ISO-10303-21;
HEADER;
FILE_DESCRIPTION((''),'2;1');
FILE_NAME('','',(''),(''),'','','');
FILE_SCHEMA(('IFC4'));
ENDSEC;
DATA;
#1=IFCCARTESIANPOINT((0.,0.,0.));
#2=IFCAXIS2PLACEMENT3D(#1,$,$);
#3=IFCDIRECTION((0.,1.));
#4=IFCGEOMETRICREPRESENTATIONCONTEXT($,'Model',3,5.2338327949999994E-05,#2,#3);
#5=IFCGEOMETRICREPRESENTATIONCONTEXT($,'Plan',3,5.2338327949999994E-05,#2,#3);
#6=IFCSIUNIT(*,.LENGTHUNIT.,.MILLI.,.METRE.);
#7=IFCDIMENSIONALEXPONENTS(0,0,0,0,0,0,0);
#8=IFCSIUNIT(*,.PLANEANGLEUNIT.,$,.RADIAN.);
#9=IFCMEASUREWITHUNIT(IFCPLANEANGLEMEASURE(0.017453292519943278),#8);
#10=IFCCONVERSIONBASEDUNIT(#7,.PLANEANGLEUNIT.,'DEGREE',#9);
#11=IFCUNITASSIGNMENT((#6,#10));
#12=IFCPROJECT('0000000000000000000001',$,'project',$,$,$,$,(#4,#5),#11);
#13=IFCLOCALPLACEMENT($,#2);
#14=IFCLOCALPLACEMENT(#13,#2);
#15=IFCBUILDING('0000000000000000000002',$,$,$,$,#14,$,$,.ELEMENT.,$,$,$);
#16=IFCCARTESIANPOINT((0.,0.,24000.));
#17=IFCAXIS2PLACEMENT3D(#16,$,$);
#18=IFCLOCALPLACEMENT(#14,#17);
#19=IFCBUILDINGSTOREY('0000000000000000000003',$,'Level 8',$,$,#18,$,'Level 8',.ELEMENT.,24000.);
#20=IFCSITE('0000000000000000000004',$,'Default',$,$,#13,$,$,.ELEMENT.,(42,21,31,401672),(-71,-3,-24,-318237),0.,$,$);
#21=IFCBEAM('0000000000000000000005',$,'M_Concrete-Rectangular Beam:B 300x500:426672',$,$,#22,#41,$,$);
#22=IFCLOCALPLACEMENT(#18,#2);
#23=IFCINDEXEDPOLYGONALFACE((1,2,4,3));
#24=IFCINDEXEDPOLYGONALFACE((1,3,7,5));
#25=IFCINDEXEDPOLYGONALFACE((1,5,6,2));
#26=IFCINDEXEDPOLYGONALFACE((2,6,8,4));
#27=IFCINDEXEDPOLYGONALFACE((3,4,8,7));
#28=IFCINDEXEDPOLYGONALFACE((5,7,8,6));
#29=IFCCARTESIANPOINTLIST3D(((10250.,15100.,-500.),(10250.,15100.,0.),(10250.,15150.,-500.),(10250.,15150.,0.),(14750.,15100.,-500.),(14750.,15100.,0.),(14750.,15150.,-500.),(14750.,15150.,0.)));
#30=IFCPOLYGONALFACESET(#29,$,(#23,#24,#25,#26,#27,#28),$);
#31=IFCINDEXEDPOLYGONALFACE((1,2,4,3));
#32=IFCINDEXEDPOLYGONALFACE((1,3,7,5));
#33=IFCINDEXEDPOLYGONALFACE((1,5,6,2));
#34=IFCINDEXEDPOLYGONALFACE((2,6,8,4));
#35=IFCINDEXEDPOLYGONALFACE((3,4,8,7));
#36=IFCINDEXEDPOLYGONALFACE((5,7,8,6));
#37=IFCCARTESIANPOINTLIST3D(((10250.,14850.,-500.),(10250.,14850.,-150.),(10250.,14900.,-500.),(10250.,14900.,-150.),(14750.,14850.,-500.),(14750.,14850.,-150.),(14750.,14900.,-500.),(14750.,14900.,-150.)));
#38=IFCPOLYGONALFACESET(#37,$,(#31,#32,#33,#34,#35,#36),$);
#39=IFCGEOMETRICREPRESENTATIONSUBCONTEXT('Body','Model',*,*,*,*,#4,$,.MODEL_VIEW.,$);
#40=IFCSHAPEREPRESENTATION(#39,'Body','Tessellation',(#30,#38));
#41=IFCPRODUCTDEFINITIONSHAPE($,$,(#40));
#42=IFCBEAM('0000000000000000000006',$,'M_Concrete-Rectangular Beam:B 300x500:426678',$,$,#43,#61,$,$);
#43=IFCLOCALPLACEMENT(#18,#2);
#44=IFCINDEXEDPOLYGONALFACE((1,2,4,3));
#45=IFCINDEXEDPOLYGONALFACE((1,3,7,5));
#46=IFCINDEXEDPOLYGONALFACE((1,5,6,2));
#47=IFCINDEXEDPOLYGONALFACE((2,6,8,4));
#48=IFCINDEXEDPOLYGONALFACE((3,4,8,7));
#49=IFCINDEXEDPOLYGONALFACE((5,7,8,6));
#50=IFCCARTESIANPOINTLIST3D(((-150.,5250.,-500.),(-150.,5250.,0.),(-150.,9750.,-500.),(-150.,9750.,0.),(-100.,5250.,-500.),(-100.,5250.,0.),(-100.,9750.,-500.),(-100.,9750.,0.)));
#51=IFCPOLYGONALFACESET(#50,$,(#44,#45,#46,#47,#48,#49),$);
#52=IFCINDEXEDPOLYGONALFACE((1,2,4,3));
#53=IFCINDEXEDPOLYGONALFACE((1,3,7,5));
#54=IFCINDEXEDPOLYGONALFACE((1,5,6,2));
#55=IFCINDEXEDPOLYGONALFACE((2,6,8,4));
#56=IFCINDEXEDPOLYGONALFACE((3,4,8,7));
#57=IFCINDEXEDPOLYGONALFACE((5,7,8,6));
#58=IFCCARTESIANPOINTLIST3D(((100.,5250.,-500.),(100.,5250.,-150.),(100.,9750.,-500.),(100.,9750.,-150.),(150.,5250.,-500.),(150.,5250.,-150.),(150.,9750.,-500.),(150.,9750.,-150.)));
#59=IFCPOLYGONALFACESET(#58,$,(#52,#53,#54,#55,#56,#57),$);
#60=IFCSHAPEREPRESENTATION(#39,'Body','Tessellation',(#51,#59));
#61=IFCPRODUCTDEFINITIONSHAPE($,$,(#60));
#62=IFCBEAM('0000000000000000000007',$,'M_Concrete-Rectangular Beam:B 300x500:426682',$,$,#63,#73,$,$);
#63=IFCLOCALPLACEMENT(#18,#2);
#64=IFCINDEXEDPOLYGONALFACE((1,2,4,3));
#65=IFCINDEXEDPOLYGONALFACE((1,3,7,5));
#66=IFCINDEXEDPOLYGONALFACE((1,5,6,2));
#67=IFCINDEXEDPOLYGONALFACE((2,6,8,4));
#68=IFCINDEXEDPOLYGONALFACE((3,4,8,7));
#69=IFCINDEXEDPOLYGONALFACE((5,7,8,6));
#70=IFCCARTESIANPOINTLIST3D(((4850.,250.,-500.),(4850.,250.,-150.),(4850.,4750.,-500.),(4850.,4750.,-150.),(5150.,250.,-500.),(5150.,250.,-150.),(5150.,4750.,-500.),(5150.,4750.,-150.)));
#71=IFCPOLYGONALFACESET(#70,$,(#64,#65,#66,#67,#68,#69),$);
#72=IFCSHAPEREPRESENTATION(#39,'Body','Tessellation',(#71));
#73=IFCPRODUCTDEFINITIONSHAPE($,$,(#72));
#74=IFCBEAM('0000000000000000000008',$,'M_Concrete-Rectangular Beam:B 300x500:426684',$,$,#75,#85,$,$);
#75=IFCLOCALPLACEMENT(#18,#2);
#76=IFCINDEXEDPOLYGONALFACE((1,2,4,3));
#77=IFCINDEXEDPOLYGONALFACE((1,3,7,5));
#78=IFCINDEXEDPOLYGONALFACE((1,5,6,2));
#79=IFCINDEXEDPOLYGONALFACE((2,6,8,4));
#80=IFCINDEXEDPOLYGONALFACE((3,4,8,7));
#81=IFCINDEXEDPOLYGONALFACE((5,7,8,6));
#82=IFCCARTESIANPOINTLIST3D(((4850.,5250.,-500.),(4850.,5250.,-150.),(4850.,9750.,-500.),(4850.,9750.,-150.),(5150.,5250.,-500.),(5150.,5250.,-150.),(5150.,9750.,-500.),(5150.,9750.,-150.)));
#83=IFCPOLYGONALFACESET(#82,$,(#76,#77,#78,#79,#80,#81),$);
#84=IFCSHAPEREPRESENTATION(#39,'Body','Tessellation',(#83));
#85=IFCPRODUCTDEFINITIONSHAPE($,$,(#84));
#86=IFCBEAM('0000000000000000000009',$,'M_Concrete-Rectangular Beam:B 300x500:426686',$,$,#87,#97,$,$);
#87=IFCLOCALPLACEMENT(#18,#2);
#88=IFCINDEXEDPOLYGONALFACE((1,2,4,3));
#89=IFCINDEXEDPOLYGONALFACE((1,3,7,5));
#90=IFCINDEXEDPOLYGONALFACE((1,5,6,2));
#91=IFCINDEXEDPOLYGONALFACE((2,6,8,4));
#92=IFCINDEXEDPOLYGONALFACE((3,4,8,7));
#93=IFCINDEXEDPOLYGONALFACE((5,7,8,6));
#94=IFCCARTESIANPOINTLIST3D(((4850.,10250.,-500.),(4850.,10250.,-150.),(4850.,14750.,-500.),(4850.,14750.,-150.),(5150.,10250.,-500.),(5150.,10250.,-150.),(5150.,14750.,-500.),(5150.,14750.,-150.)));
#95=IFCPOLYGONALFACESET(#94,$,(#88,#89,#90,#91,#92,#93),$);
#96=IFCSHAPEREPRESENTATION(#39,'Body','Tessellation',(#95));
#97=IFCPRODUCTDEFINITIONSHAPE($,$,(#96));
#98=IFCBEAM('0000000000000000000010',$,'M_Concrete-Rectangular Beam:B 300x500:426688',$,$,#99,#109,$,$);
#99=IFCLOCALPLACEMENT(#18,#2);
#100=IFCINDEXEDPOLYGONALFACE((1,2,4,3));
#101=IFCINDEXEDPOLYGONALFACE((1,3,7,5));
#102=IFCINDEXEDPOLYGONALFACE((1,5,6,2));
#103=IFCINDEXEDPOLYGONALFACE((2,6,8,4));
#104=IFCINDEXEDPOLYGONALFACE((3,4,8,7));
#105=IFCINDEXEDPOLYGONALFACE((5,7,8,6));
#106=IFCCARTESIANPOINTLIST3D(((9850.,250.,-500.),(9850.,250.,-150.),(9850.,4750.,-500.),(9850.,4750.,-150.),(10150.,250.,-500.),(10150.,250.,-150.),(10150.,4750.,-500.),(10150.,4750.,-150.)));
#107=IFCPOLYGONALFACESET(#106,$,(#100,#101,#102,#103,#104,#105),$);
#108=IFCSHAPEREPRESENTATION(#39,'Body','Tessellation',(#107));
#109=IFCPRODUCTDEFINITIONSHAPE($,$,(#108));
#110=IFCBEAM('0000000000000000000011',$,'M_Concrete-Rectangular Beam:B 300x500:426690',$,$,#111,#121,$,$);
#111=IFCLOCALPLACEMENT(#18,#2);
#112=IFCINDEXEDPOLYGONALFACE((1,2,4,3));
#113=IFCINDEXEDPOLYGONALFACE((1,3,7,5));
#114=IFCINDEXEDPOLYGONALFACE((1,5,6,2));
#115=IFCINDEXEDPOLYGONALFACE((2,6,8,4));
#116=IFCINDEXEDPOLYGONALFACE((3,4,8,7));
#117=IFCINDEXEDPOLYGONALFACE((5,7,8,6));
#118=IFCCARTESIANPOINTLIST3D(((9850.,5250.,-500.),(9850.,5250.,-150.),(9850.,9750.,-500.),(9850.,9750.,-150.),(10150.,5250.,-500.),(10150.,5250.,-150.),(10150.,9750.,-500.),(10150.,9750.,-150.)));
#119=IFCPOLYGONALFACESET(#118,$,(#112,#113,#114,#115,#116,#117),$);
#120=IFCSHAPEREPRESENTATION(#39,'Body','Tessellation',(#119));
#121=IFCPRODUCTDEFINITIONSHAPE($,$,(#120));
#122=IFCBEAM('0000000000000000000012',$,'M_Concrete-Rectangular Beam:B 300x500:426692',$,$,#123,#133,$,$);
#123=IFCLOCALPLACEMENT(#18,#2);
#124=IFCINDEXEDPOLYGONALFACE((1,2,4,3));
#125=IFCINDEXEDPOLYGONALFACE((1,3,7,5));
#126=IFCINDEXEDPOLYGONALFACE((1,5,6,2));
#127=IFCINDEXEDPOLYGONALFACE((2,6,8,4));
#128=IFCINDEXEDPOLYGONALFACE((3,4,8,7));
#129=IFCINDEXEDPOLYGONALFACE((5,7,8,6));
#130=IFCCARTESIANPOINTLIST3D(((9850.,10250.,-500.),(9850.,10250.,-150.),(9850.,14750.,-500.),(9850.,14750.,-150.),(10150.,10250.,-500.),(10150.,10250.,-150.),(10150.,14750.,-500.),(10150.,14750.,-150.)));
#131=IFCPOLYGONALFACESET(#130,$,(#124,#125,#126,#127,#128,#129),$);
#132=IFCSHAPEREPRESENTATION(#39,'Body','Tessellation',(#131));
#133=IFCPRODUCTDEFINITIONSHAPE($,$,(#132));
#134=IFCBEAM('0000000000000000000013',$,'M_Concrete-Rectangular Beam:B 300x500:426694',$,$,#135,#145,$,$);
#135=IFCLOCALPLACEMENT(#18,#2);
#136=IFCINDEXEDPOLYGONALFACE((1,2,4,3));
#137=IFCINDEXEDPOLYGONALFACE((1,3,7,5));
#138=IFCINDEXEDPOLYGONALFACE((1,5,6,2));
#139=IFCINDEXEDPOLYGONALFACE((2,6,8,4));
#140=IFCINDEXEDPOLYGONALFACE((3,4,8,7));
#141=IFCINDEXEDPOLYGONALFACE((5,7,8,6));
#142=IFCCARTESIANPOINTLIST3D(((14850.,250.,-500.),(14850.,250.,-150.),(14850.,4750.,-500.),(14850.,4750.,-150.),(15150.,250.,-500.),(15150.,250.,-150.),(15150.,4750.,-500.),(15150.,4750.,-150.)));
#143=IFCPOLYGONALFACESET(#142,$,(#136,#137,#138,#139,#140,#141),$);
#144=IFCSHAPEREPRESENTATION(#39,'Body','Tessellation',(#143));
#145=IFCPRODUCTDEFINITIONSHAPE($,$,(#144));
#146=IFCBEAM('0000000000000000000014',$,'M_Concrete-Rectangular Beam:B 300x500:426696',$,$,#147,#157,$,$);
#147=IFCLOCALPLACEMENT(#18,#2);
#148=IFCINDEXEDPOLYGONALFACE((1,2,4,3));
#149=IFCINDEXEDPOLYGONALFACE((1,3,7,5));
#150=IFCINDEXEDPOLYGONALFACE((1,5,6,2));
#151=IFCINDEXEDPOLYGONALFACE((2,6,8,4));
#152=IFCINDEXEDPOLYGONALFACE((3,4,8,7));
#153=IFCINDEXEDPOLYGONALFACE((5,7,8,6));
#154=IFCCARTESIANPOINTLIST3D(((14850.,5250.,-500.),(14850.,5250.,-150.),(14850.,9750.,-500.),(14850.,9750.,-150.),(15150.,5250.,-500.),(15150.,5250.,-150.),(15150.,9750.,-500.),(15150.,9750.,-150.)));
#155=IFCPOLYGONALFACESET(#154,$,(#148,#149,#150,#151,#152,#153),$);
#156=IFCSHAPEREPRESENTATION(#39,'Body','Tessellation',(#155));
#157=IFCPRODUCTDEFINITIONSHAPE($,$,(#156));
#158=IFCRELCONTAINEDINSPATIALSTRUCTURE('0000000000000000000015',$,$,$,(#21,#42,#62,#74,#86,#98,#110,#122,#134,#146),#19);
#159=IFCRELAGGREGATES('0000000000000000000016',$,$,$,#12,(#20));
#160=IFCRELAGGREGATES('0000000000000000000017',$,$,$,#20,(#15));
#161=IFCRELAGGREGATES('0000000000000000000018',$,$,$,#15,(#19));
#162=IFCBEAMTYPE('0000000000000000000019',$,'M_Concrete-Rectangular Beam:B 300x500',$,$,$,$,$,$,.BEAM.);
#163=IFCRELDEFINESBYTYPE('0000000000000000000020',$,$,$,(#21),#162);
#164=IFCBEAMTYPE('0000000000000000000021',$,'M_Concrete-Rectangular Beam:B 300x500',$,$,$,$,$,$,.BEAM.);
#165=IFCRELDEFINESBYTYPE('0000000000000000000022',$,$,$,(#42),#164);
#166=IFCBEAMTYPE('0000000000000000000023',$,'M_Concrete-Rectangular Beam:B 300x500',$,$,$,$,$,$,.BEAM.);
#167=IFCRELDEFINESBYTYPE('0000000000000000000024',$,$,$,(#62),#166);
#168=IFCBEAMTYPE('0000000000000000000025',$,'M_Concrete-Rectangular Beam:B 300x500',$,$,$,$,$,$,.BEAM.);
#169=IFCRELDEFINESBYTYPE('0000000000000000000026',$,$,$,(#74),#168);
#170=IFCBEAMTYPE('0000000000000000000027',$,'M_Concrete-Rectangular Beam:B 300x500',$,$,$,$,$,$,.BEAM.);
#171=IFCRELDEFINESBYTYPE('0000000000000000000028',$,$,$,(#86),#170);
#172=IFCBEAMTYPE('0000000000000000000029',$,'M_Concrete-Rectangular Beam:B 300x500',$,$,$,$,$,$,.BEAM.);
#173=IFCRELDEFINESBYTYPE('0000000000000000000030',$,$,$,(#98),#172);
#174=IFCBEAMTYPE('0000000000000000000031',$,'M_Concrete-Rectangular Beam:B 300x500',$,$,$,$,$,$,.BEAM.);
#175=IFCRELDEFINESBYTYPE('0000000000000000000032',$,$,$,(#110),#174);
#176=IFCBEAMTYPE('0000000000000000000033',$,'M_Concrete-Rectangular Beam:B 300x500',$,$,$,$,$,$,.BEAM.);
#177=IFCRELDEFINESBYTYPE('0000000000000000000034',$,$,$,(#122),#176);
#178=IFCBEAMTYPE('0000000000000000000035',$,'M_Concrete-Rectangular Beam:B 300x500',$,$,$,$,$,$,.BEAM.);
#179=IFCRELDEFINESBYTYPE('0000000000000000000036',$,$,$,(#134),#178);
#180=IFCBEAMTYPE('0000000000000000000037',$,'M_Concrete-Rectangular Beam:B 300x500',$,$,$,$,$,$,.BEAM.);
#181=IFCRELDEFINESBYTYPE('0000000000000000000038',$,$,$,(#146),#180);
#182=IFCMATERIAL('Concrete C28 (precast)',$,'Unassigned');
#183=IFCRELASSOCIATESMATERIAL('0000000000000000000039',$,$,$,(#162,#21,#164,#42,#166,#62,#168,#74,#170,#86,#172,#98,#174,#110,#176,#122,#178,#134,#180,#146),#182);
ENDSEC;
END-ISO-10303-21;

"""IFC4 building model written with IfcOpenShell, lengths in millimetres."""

from ifc_helpers import new_model, entity, si_unit, converted_unit, direction, frame, origin, place, context, subcontext, project, spatial, indexed_curve, outline, extrude, source, transform, mapped, material, type_object, type_shapes, element, save


model = new_model("IFC4")

# Units and contexts
model_context = context("Model", 3, precision=5.2338327949999994e-05, world=origin(), true_north=direction((0.0, 1.0)))
plan_context = context("Plan", 3, precision=5.2338327949999994e-05, world=origin(), true_north=direction((0.0, 1.0)))
body_context = subcontext(model_context, "Body", "Model", "MODEL_VIEW")
ifc_project = project(units=[si_unit("LENGTHUNIT", "METRE", prefix="MILLI"), converted_unit("PLANEANGLEUNIT", "DEGREE", entity("IfcPlaneAngleMeasure", 0.017453292519943278), si_unit("PLANEANGLEUNIT", "RADIAN"), dimensions=[0, 0, 0, 0, 0, 0, 0])], contexts=[model_context, plan_context])

# Site, building, storey
site_placement = place(None, origin())
site = spatial("IfcSite", under=ifc_project, at=site_placement, Name="Default", CompositionType="ELEMENT", RefLatitude=(42, 21, 31, 401672), RefLongitude=(-71, -3, -24, -318237), RefElevation=0.0)
building_placement = place(site_placement, origin())
building = spatial("IfcBuilding", under=site, at=building_placement, CompositionType="ELEMENT")
storey_placement = place(building_placement, frame((0.0, 0.0, 24000.0)))
storey = spatial("IfcBuildingStorey", under=building, at=storey_placement, Name="Level 8", LongName="Level 8", CompositionType="ELEMENT", Elevation=24000.0)

# Beams
ifc_material = material(Name="Concrete C28 (precast)", Category="Unassigned")
beam_type_1 = type_object("IfcBeamType", Name="M_Concrete-Rectangular Beam:B 300x500", PredefinedType="BEAM", material=ifc_material)
shared_shape_1 = source(origin(), body_context, "Body", "SweptSolid", [
    extrude(outline(indexed_curve([(-250.0, -25.0), (250.0, -25.0), (250.0, 25.0), (-250.0, 25.0), (-250.0, -25.0)], self_intersect=False)), frame((10250.0, 15125.0, 23750.0), z_axis=(1.0, 0.0, 0.0), x_axis=(0.0, 0.0, -1.0)), (0.0, 0.0, 1.0), 4500.0),
    extrude(outline(indexed_curve([(-175.0, -25.0), (175.0, -25.0), (175.0, 25.0), (-175.0, 25.0), (-175.0, -25.0)], self_intersect=False)), frame((10250.0, 14875.0, 23675.0), z_axis=(1.0, 0.0, 0.0), x_axis=(0.0, 0.0, -1.0)), (0.0, 0.0, 1.0), 4500.0),
])
type_shapes(beam_type_1, [shared_shape_1])
beam_1_placement = place(storey_placement, frame((0.0, 0.0, -24000.0)))
element("IfcBeam", 1, at=beam_1_placement, inside=storey, type_object=beam_type_1, material=ifc_material, Name="M_Concrete-Rectangular Beam:B 300x500:426672", context=body_context, shape_type="MappedRepresentation", body=[
    mapped(shared_shape_1, transform((0.0, 0.0, 0.0), scale=1.0)),
])
beam_type_2 = type_object("IfcBeamType", Name="M_Concrete-Rectangular Beam:B 300x500", PredefinedType="BEAM", material=ifc_material)
shared_shape_2 = source(origin(), body_context, "Body", "SweptSolid", [
    extrude(outline(indexed_curve([(-25.0, -250.0), (25.0, -250.0), (25.0, 250.0), (-25.0, 250.0), (-25.0, -250.0)], self_intersect=False)), frame((-125.0, 5250.0, 23750.0), z_axis=(0.0, 1.0, 0.0), x_axis=(-1.0, 0.0, 0.0)), (0.0, 0.0, 1.0), 4500.0),
    extrude(outline(indexed_curve([(-25.0, -175.0), (25.0, -175.0), (25.0, 175.0), (-25.0, 175.0), (-25.0, -175.0)], self_intersect=False)), frame((125.0, 5250.0, 23675.0), z_axis=(0.0, 1.0, 0.0), x_axis=(-1.0, 0.0, 0.0)), (0.0, 0.0, 1.0), 4500.0),
])
type_shapes(beam_type_2, [shared_shape_2])
beam_2_placement = place(storey_placement, frame((0.0, 0.0, -24000.0)))
element("IfcBeam", 2, at=beam_2_placement, inside=storey, type_object=beam_type_2, material=ifc_material, Name="M_Concrete-Rectangular Beam:B 300x500:426678", context=body_context, shape_type="MappedRepresentation", body=[
    mapped(shared_shape_2, transform((0.0, 0.0, 0.0), scale=1.0)),
])
beam_type_3 = type_object("IfcBeamType", Name="M_Concrete-Rectangular Beam:B 300x500", PredefinedType="BEAM", material=ifc_material)
shared_shape_3 = source(origin(), body_context, "Body", "SweptSolid", [
    extrude(outline(indexed_curve([(-150.0, -175.0), (150.0, -175.0), (150.0, 175.0), (-150.0, 175.0), (-150.0, -175.0)], self_intersect=False)), frame((5000.0, 250.0, 23675.0), z_axis=(0.0, 1.0, 0.0), x_axis=(-1.0, 0.0, 0.0)), (0.0, 0.0, 1.0), 4500.0),
])
type_shapes(beam_type_3, [shared_shape_3])
beam_3_placement = place(storey_placement, frame((0.0, 0.0, -24000.0)))
element("IfcBeam", 3, at=beam_3_placement, inside=storey, type_object=beam_type_3, material=ifc_material, Name="M_Concrete-Rectangular Beam:B 300x500:426682", context=body_context, shape_type="MappedRepresentation", body=[
    mapped(shared_shape_3, transform((0.0, 0.0, 0.0), scale=1.0)),
])
beam_type_4 = type_object("IfcBeamType", Name="M_Concrete-Rectangular Beam:B 300x500", PredefinedType="BEAM", material=ifc_material)
shared_shape_4 = source(origin(), body_context, "Body", "SweptSolid", [
    extrude(outline(indexed_curve([(-150.0, -175.0), (150.0, -175.0), (150.0, 175.0), (-150.0, 175.0), (-150.0, -175.0)], self_intersect=False)), frame((5000.0, 5250.0, 23675.0), z_axis=(0.0, 1.0, 0.0), x_axis=(-1.0, 0.0, 0.0)), (0.0, 0.0, 1.0), 4500.0),
])
type_shapes(beam_type_4, [shared_shape_4])
beam_4_placement = place(storey_placement, frame((0.0, 0.0, -24000.0)))
element("IfcBeam", 4, at=beam_4_placement, inside=storey, type_object=beam_type_4, material=ifc_material, Name="M_Concrete-Rectangular Beam:B 300x500:426684", context=body_context, shape_type="MappedRepresentation", body=[
    mapped(shared_shape_4, transform((0.0, 0.0, 0.0), scale=1.0)),
])
beam_type_5 = type_object("IfcBeamType", Name="M_Concrete-Rectangular Beam:B 300x500", PredefinedType="BEAM", material=ifc_material)
shared_shape_5 = source(origin(), body_context, "Body", "SweptSolid", [
    extrude(outline(indexed_curve([(-150.0, -175.0), (150.0, -175.0), (150.0, 175.0), (-150.0, 175.0), (-150.0, -175.0)], self_intersect=False)), frame((5000.0, 10250.0, 23675.0), z_axis=(0.0, 1.0, 0.0), x_axis=(-1.0, 0.0, 0.0)), (0.0, 0.0, 1.0), 4500.0),
])
type_shapes(beam_type_5, [shared_shape_5])
beam_5_placement = place(storey_placement, frame((0.0, 0.0, -24000.0)))
element("IfcBeam", 5, at=beam_5_placement, inside=storey, type_object=beam_type_5, material=ifc_material, Name="M_Concrete-Rectangular Beam:B 300x500:426686", context=body_context, shape_type="MappedRepresentation", body=[
    mapped(shared_shape_5, transform((0.0, 0.0, 0.0), scale=1.0)),
])
beam_type_6 = type_object("IfcBeamType", Name="M_Concrete-Rectangular Beam:B 300x500", PredefinedType="BEAM", material=ifc_material)
shared_shape_6 = source(origin(), body_context, "Body", "SweptSolid", [
    extrude(outline(indexed_curve([(-150.0, -175.0), (150.0, -175.0), (150.0, 175.0), (-150.0, 175.0), (-150.0, -175.0)], self_intersect=False)), frame((10000.0, 250.0, 23675.0), z_axis=(0.0, 1.0, 0.0), x_axis=(-1.0, 0.0, 0.0)), (0.0, 0.0, 1.0), 4500.0),
])
type_shapes(beam_type_6, [shared_shape_6])
beam_6_placement = place(storey_placement, frame((0.0, 0.0, -24000.0)))
element("IfcBeam", 6, at=beam_6_placement, inside=storey, type_object=beam_type_6, material=ifc_material, Name="M_Concrete-Rectangular Beam:B 300x500:426688", context=body_context, shape_type="MappedRepresentation", body=[
    mapped(shared_shape_6, transform((0.0, 0.0, 0.0), scale=1.0)),
])
beam_type_7 = type_object("IfcBeamType", Name="M_Concrete-Rectangular Beam:B 300x500", PredefinedType="BEAM", material=ifc_material)
shared_shape_7 = source(origin(), body_context, "Body", "SweptSolid", [
    extrude(outline(indexed_curve([(-150.0, -175.0), (150.0, -175.0), (150.0, 175.0), (-150.0, 175.0), (-150.0, -175.0)], self_intersect=False)), frame((10000.0, 5250.0, 23675.0), z_axis=(0.0, 1.0, 0.0), x_axis=(-1.0, 0.0, 0.0)), (0.0, 0.0, 1.0), 4500.0),
])
type_shapes(beam_type_7, [shared_shape_7])
beam_7_placement = place(storey_placement, frame((0.0, 0.0, -24000.0)))
element("IfcBeam", 7, at=beam_7_placement, inside=storey, type_object=beam_type_7, material=ifc_material, Name="M_Concrete-Rectangular Beam:B 300x500:426690", context=body_context, shape_type="MappedRepresentation", body=[
    mapped(shared_shape_7, transform((0.0, 0.0, 0.0), scale=1.0)),
])
beam_type_8 = type_object("IfcBeamType", Name="M_Concrete-Rectangular Beam:B 300x500", PredefinedType="BEAM", material=ifc_material)
shared_shape_8 = source(origin(), body_context, "Body", "SweptSolid", [
    extrude(outline(indexed_curve([(-150.0, -175.0), (150.0, -175.0), (150.0, 175.0), (-150.0, 175.0), (-150.0, -175.0)], self_intersect=False)), frame((10000.0, 10250.0, 23675.0), z_axis=(0.0, 1.0, 0.0), x_axis=(-1.0, 0.0, 0.0)), (0.0, 0.0, 1.0), 4500.0),
])
type_shapes(beam_type_8, [shared_shape_8])
beam_8_placement = place(storey_placement, frame((0.0, 0.0, -24000.0)))
element("IfcBeam", 8, at=beam_8_placement, inside=storey, type_object=beam_type_8, material=ifc_material, Name="M_Concrete-Rectangular Beam:B 300x500:426692", context=body_context, shape_type="MappedRepresentation", body=[
    mapped(shared_shape_8, transform((0.0, 0.0, 0.0), scale=1.0)),
])
beam_type_9 = type_object("IfcBeamType", Name="M_Concrete-Rectangular Beam:B 300x500", PredefinedType="BEAM", material=ifc_material)
shared_shape_9 = source(origin(), body_context, "Body", "SweptSolid", [
    extrude(outline(indexed_curve([(-150.0, -175.0), (150.0, -175.0), (150.0, 175.0), (-150.0, 175.0), (-150.0, -175.0)], self_intersect=False)), frame((15000.0, 250.0, 23675.0), z_axis=(0.0, 1.0, 0.0), x_axis=(-1.0, 0.0, 0.0)), (0.0, 0.0, 1.0), 4500.0),
])
type_shapes(beam_type_9, [shared_shape_9])
beam_9_placement = place(storey_placement, frame((0.0, 0.0, -24000.0)))
element("IfcBeam", 9, at=beam_9_placement, inside=storey, type_object=beam_type_9, material=ifc_material, Name="M_Concrete-Rectangular Beam:B 300x500:426694", context=body_context, shape_type="MappedRepresentation", body=[
    mapped(shared_shape_9, transform((0.0, 0.0, 0.0), scale=1.0)),
])
beam_type_10 = type_object("IfcBeamType", Name="M_Concrete-Rectangular Beam:B 300x500", PredefinedType="BEAM", material=ifc_material)
shared_shape_10 = source(origin(), body_context, "Body", "SweptSolid", [
    extrude(outline(indexed_curve([(-150.0, -175.0), (150.0, -175.0), (150.0, 175.0), (-150.0, 175.0), (-150.0, -175.0)], self_intersect=False)), frame((15000.0, 5250.0, 23675.0), z_axis=(0.0, 1.0, 0.0), x_axis=(-1.0, 0.0, 0.0)), (0.0, 0.0, 1.0), 4500.0),
])
type_shapes(beam_type_10, [shared_shape_10])
beam_10_placement = place(storey_placement, frame((0.0, 0.0, -24000.0)))
element("IfcBeam", 10, at=beam_10_placement, inside=storey, type_object=beam_type_10, material=ifc_material, Name="M_Concrete-Rectangular Beam:B 300x500:426696", context=body_context, shape_type="MappedRepresentation", body=[
    mapped(shared_shape_10, transform((0.0, 0.0, 0.0), scale=1.0)),
])

save(model, "model.ifc")
